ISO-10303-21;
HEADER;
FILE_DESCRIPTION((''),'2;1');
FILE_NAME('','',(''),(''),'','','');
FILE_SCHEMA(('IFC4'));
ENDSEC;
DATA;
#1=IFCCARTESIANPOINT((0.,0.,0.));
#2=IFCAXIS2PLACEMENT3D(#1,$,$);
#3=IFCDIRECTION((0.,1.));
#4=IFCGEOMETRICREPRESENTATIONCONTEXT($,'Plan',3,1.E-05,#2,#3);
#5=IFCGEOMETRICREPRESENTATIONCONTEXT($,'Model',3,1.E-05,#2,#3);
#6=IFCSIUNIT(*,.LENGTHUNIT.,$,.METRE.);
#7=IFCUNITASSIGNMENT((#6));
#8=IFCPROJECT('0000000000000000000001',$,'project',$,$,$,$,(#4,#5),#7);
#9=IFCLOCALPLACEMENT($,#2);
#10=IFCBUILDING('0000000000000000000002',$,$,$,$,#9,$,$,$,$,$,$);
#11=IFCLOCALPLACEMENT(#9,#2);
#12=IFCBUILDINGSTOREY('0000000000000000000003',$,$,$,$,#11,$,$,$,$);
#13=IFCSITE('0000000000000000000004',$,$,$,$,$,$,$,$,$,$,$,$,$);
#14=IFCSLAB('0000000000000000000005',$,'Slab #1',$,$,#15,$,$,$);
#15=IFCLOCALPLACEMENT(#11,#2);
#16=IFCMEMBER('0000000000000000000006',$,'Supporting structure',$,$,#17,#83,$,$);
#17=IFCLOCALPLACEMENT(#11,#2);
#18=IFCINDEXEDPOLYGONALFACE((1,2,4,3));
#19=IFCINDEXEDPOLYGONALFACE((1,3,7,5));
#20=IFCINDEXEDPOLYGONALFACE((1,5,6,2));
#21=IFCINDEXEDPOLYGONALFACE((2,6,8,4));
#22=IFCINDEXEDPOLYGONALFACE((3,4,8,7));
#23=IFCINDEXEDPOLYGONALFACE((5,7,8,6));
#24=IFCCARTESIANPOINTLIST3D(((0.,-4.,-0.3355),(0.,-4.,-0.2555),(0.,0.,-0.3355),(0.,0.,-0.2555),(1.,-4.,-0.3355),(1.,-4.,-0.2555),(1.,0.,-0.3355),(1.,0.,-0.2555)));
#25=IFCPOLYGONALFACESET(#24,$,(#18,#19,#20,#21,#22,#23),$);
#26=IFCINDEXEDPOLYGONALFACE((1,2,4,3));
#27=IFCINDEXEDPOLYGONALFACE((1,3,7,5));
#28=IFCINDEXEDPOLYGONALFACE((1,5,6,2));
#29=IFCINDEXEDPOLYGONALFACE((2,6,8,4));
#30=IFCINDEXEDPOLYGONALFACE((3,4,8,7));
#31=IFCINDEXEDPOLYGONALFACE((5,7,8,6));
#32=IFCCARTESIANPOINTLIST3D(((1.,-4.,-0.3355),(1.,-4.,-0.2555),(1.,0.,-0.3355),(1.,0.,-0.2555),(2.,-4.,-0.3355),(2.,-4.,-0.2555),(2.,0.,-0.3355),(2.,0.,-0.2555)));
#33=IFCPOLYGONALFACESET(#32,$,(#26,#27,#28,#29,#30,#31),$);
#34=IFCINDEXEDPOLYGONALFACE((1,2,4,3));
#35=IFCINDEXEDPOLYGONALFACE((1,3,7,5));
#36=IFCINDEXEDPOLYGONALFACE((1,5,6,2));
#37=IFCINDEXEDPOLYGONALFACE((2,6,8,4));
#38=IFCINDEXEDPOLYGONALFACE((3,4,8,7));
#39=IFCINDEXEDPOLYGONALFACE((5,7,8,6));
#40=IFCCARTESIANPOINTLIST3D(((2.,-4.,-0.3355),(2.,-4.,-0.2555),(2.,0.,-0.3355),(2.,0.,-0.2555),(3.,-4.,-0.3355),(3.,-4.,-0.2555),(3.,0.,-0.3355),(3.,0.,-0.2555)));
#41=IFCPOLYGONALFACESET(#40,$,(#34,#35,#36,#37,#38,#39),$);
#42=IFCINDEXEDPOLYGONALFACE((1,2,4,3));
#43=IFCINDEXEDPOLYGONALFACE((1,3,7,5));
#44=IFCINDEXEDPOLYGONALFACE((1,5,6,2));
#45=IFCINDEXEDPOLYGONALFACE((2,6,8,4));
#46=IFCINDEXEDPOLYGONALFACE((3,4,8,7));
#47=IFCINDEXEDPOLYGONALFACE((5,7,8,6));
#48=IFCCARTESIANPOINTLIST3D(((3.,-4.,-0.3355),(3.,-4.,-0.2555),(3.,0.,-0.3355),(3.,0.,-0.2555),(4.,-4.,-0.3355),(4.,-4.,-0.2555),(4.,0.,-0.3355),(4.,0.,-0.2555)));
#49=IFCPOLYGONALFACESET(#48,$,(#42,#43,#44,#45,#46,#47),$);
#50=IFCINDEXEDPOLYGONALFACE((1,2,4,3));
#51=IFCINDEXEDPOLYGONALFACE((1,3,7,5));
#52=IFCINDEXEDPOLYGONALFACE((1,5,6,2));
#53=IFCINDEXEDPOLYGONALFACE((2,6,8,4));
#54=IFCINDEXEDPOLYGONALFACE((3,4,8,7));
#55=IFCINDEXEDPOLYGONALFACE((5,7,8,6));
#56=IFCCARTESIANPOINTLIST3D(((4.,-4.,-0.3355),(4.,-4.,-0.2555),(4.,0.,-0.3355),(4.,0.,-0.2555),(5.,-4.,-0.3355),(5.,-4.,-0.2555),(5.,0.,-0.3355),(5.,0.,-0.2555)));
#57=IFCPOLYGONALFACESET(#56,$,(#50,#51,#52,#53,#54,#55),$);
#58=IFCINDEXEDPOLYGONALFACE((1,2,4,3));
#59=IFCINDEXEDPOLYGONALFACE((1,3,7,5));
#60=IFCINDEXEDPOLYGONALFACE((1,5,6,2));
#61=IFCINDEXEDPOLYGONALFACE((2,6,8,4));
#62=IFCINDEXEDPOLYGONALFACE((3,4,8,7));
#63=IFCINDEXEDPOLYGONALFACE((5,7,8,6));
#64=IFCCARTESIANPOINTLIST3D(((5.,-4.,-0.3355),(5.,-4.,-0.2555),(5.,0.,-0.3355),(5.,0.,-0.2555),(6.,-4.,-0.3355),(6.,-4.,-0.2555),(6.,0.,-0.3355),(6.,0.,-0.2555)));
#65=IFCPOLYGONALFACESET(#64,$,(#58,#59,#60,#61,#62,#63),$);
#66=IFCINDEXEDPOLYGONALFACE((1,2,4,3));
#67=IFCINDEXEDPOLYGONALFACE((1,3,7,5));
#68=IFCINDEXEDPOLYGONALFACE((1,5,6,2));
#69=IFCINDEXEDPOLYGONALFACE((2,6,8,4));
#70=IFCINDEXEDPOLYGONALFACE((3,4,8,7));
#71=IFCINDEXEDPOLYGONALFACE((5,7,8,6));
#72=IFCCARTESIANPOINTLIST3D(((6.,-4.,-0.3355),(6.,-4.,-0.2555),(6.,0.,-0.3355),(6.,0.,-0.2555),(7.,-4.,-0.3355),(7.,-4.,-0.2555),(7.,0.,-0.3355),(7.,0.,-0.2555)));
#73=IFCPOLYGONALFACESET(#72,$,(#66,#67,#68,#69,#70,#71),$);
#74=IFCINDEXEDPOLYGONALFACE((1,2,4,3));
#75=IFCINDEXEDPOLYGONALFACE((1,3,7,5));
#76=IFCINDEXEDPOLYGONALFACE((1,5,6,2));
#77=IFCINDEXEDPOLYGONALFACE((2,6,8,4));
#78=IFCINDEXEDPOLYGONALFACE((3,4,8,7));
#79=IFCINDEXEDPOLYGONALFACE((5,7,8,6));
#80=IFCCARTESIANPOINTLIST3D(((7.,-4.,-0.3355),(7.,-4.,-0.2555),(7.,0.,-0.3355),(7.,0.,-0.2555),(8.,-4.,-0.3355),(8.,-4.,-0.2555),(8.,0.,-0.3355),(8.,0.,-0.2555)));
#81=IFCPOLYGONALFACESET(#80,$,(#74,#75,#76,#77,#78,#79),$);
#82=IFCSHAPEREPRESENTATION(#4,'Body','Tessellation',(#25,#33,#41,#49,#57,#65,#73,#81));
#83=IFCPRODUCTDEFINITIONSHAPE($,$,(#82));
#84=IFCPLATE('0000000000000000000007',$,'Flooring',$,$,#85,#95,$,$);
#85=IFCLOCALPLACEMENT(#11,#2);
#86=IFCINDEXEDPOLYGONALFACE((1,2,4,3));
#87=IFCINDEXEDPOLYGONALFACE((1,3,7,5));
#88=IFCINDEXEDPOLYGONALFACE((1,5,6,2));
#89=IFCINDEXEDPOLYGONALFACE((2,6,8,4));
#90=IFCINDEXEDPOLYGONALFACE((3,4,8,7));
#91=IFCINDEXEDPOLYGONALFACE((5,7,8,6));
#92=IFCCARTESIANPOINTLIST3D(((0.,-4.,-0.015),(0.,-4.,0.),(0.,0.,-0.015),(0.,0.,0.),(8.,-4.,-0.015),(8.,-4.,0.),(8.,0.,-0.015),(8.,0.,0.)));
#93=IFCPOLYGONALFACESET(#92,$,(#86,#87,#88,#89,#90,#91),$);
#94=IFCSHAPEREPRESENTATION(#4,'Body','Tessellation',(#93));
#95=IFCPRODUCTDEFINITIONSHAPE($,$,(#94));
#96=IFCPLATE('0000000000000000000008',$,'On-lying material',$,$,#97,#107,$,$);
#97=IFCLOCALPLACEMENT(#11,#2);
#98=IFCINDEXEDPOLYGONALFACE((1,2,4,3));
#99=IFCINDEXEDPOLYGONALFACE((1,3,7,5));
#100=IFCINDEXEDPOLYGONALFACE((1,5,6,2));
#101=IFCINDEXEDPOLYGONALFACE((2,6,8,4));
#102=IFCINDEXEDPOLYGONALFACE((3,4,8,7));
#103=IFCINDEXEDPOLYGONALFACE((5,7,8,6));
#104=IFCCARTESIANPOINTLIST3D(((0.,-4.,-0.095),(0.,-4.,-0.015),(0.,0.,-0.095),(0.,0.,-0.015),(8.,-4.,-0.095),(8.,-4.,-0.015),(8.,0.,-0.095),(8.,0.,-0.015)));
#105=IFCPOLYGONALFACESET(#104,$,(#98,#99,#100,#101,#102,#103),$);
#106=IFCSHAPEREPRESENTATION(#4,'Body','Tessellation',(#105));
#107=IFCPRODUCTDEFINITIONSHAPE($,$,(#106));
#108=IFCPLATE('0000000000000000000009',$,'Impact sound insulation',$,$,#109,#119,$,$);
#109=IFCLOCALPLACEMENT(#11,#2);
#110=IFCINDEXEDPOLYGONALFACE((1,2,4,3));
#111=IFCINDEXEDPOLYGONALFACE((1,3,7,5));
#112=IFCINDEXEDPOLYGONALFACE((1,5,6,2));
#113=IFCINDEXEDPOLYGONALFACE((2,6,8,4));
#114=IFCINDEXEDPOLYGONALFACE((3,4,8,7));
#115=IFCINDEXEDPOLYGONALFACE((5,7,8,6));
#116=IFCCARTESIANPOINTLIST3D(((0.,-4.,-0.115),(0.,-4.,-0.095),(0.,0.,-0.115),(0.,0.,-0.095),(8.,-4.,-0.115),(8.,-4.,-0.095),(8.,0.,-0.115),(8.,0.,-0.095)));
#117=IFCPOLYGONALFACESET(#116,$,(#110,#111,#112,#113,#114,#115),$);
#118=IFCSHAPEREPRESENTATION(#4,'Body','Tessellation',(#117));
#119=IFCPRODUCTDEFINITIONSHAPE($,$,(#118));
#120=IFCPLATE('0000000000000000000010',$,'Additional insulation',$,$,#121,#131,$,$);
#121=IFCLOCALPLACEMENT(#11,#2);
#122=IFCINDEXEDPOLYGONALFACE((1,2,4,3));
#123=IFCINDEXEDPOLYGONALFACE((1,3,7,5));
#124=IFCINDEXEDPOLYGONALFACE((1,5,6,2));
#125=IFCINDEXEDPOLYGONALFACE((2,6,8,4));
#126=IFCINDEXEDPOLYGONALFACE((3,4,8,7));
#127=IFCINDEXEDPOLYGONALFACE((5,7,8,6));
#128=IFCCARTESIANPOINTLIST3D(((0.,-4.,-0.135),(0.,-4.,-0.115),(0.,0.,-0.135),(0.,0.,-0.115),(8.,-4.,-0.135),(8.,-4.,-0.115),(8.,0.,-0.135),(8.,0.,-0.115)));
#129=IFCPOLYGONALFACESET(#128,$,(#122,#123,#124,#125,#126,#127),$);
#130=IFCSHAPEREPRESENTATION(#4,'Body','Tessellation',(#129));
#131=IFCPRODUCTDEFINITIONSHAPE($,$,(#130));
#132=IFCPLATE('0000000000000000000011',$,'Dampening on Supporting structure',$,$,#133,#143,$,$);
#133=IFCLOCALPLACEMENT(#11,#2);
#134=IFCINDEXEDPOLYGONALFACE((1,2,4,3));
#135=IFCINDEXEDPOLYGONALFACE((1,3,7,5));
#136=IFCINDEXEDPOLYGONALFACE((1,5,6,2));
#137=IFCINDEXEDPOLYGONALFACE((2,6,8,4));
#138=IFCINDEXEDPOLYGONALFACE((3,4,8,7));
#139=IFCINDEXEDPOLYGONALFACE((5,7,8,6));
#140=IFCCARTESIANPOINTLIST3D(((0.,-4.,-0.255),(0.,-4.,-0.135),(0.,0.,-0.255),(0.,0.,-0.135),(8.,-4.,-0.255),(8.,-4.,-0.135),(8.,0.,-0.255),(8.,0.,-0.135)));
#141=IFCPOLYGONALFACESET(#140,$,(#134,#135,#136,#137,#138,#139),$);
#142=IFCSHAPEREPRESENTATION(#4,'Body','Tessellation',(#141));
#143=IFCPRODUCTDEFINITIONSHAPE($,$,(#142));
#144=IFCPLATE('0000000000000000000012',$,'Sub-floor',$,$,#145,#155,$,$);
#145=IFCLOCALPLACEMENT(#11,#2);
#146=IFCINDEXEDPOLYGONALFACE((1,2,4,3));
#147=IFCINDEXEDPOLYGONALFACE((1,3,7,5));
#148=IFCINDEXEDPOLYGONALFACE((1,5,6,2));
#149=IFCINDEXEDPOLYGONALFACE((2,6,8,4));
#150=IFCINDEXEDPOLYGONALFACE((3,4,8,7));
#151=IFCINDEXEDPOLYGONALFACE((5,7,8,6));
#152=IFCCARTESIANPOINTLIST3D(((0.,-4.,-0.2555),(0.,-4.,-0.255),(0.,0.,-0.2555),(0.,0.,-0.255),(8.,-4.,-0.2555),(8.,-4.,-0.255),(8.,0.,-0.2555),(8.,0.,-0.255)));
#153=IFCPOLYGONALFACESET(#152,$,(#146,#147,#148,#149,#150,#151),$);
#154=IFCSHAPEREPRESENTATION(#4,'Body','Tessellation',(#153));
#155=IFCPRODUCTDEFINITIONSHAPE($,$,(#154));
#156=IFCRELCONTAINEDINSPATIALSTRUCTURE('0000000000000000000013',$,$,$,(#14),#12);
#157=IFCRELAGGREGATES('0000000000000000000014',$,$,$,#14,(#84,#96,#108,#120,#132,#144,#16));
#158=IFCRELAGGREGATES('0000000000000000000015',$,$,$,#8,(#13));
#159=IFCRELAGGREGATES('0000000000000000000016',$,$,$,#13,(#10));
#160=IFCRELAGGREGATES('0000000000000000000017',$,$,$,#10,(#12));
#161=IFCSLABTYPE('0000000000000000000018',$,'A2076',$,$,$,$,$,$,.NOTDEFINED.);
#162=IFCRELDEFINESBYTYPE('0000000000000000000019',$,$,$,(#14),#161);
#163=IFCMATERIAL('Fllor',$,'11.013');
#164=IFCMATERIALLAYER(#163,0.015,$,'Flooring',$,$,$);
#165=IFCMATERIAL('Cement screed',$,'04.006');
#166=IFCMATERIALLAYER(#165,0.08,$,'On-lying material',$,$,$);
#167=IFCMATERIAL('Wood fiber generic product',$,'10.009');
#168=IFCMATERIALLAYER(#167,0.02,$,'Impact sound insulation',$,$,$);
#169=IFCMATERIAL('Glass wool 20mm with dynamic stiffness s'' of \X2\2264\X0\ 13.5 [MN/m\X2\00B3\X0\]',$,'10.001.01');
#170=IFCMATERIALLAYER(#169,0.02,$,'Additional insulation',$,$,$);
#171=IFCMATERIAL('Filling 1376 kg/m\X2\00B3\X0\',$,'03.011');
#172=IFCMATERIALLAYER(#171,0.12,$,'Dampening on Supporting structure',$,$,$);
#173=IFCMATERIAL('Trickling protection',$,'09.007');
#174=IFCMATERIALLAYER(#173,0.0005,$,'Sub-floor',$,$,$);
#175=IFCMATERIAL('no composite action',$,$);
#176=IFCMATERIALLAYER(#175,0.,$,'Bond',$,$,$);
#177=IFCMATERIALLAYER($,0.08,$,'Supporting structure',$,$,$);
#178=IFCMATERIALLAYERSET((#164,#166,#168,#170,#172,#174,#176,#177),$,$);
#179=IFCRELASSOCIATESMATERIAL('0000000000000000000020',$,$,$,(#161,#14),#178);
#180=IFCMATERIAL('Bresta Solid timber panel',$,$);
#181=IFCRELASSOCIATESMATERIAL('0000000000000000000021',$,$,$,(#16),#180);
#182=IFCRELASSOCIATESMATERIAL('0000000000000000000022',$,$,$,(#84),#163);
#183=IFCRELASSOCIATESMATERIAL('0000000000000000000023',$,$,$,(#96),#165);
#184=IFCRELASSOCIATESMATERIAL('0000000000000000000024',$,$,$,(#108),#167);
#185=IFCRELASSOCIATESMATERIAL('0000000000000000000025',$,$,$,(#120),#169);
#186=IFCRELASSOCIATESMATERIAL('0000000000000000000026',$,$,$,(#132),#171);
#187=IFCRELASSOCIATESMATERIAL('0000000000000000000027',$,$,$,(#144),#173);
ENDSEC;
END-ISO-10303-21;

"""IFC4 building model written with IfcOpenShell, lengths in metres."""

from ifc_helpers import new_model, si_unit, direction, frame, frame_2d, origin, origin_with_axes, place, context, project, spatial, rectangle, extrude, material, layer, layer_set, type_object, element, aggregate, save


model = new_model("IFC4")

# Units and contexts
plan_context = context("Plan", 3, precision=1e-05, world=origin(), true_north=direction((0.0, 1.0)))
model_context = context("Model", 3, precision=1e-05, world=origin(), true_north=direction((0.0, 1.0)))
ifc_project = project(units=[si_unit("LENGTHUNIT", "METRE")], contexts=[plan_context, model_context])

# Site, building, storey
site = spatial("IfcSite", under=ifc_project)
building_placement = place(None, origin())
building = spatial("IfcBuilding", under=site, at=building_placement)
storey_placement = place(building_placement, origin())
storey = spatial("IfcBuildingStorey", under=building, at=storey_placement)

# Slab, member, plates
ifc_material_1 = material(Name="Fllor", Category="11.013")
ifc_layer_1 = layer(ifc_material_1, 0.015, Name="Flooring")
ifc_material_2 = material(Name="Cement screed", Category="04.006")
ifc_layer_2 = layer(ifc_material_2, 0.08, Name="On-lying material")
ifc_material_3 = material(Name="Wood fiber generic product", Category="10.009")
ifc_layer_3 = layer(ifc_material_3, 0.02, Name="Impact sound insulation")
ifc_material_4 = material(Name="Glass wool 20mm with dynamic stiffness s' of ≤ 13.5 [MN/m³]", Category="10.001.01")
ifc_layer_4 = layer(ifc_material_4, 0.02, Name="Additional insulation")
ifc_material_5 = material(Name="Filling 1376 kg/m³", Category="03.011")
ifc_layer_5 = layer(ifc_material_5, 0.12, Name="Dampening on Supporting structure")
ifc_material_6 = material(Name="Trickling protection", Category="09.007")
ifc_layer_6 = layer(ifc_material_6, 0.0005, Name="Sub-floor")
ifc_material_7 = material(Name="no composite action")
ifc_layer_7 = layer(ifc_material_7, 0.0, Name="Bond")
ifc_layer_8 = layer(None, 0.08, Name="Supporting structure")
ifc_layer_set = layer_set([ifc_layer_1, ifc_layer_2, ifc_layer_3, ifc_layer_4, ifc_layer_5, ifc_layer_6, ifc_layer_7, ifc_layer_8])
slab_type = type_object("IfcSlabType", Name="A2076", PredefinedType="NOTDEFINED", material=ifc_layer_set)
slab_placement = place(None, frame((0.0, 0.0, 0.0), z_axis=(0.0, 0.0, -1.0), x_axis=(1.0, 0.0, 0.0)))
slab = element("IfcSlab", 1, at=slab_placement, inside=storey, type_object=slab_type, material=ifc_layer_set, Name="Slab #1")
ifc_material_8 = material(Name="Bresta Solid timber panel")
member_placement = place(slab_placement, origin())
member = element("IfcMember", 2, at=member_placement, material=ifc_material_8, Name="Supporting structure", context=plan_context, shape_type="SweptSolid", body=[
    extrude(rectangle(XDim=1.0, YDim=0.08, at=frame_2d((0.5, 0.04), x_axis=(1.0, 0.0))), frame((0.0, 4.0, 0.2555), z_axis=(0.0, -1.0, 0.0), x_axis=(1.0, 0.0, 0.0)), (0.0, 0.0, 1.0), 4.0),
    extrude(rectangle(XDim=1.0, YDim=0.08, at=frame_2d((0.5, 0.04), x_axis=(1.0, 0.0))), frame((1.0, 4.0, 0.2555), z_axis=(0.0, -1.0, 0.0), x_axis=(1.0, 0.0, 0.0)), (0.0, 0.0, 1.0), 4.0),
    extrude(rectangle(XDim=1.0, YDim=0.08, at=frame_2d((0.5, 0.04), x_axis=(1.0, 0.0))), frame((2.0, 4.0, 0.2555), z_axis=(0.0, -1.0, 0.0), x_axis=(1.0, 0.0, 0.0)), (0.0, 0.0, 1.0), 4.0),
    extrude(rectangle(XDim=1.0, YDim=0.08, at=frame_2d((0.5, 0.04), x_axis=(1.0, 0.0))), frame((3.0, 4.0, 0.2555), z_axis=(0.0, -1.0, 0.0), x_axis=(1.0, 0.0, 0.0)), (0.0, 0.0, 1.0), 4.0),
    extrude(rectangle(XDim=1.0, YDim=0.08, at=frame_2d((0.5, 0.04), x_axis=(1.0, 0.0))), frame((4.0, 4.0, 0.2555), z_axis=(0.0, -1.0, 0.0), x_axis=(1.0, 0.0, 0.0)), (0.0, 0.0, 1.0), 4.0),
    extrude(rectangle(XDim=1.0, YDim=0.08, at=frame_2d((0.5, 0.04), x_axis=(1.0, 0.0))), frame((5.0, 4.0, 0.2555), z_axis=(0.0, -1.0, 0.0), x_axis=(1.0, 0.0, 0.0)), (0.0, 0.0, 1.0), 4.0),
    extrude(rectangle(XDim=1.0, YDim=0.08, at=frame_2d((0.5, 0.04), x_axis=(1.0, 0.0))), frame((6.0, 4.0, 0.2555), z_axis=(0.0, -1.0, 0.0), x_axis=(1.0, 0.0, 0.0)), (0.0, 0.0, 1.0), 4.0),
    extrude(rectangle(XDim=1.0, YDim=0.08, at=frame_2d((0.5, 0.04), x_axis=(1.0, 0.0))), frame((7.0, 4.0, 0.2555), z_axis=(0.0, -1.0, 0.0), x_axis=(1.0, 0.0, 0.0)), (0.0, 0.0, 1.0), 4.0),
])
plate_1_placement = place(slab_placement, origin())
plate_1 = element("IfcPlate", 3, at=plate_1_placement, material=ifc_material_1, Name="Flooring", context=plan_context, shape_type="SweptSolid", body=[
    extrude(rectangle(XDim=8.0, YDim=4.0, at=frame_2d((4.0, 2.0), x_axis=(1.0, 0.0))), origin_with_axes(), (0.0, 0.0, 1.0), 0.015),
])
plate_2_placement = place(slab_placement, origin())
plate_2 = element("IfcPlate", 4, at=plate_2_placement, material=ifc_material_2, Name="On-lying material", context=plan_context, shape_type="SweptSolid", body=[
    extrude(rectangle(XDim=8.0, YDim=4.0, at=frame_2d((4.0, 2.0), x_axis=(1.0, 0.0))), frame((0.0, 0.0, 0.015), z_axis=(0.0, 0.0, 1.0), x_axis=(1.0, 0.0, 0.0)), (0.0, 0.0, 1.0), 0.08),
])
plate_3_placement = place(slab_placement, origin())
plate_3 = element("IfcPlate", 5, at=plate_3_placement, material=ifc_material_3, Name="Impact sound insulation", context=plan_context, shape_type="SweptSolid", body=[
    extrude(rectangle(XDim=8.0, YDim=4.0, at=frame_2d((4.0, 2.0), x_axis=(1.0, 0.0))), frame((0.0, 0.0, 0.095), z_axis=(0.0, 0.0, 1.0), x_axis=(1.0, 0.0, 0.0)), (0.0, 0.0, 1.0), 0.02),
])
plate_4_placement = place(slab_placement, origin())
plate_4 = element("IfcPlate", 6, at=plate_4_placement, material=ifc_material_4, Name="Additional insulation", context=plan_context, shape_type="SweptSolid", body=[
    extrude(rectangle(XDim=8.0, YDim=4.0, at=frame_2d((4.0, 2.0), x_axis=(1.0, 0.0))), frame((0.0, 0.0, 0.115), z_axis=(0.0, 0.0, 1.0), x_axis=(1.0, 0.0, 0.0)), (0.0, 0.0, 1.0), 0.02),
])
plate_5_placement = place(slab_placement, origin())
plate_5 = element("IfcPlate", 7, at=plate_5_placement, material=ifc_material_5, Name="Dampening on Supporting structure", context=plan_context, shape_type="SweptSolid", body=[
    extrude(rectangle(XDim=8.0, YDim=4.0, at=frame_2d((4.0, 2.0), x_axis=(1.0, 0.0))), frame((0.0, 0.0, 0.135), z_axis=(0.0, 0.0, 1.0), x_axis=(1.0, 0.0, 0.0)), (0.0, 0.0, 1.0), 0.12),
])
plate_6_placement = place(slab_placement, origin())
plate_6 = element("IfcPlate", 8, at=plate_6_placement, material=ifc_material_6, Name="Sub-floor", context=plan_context, shape_type="SweptSolid", body=[
    extrude(rectangle(XDim=8.0, YDim=4.0, at=frame_2d((4.0, 2.0), x_axis=(1.0, 0.0))), frame((0.0, 0.0, 0.255), z_axis=(0.0, 0.0, 1.0), x_axis=(1.0, 0.0, 0.0)), (0.0, 0.0, 1.0), 0.0005),
])
aggregate(slab, [plate_1, plate_2, plate_3, plate_4, plate_5, plate_6, member])

save(model, "model.ifc")
